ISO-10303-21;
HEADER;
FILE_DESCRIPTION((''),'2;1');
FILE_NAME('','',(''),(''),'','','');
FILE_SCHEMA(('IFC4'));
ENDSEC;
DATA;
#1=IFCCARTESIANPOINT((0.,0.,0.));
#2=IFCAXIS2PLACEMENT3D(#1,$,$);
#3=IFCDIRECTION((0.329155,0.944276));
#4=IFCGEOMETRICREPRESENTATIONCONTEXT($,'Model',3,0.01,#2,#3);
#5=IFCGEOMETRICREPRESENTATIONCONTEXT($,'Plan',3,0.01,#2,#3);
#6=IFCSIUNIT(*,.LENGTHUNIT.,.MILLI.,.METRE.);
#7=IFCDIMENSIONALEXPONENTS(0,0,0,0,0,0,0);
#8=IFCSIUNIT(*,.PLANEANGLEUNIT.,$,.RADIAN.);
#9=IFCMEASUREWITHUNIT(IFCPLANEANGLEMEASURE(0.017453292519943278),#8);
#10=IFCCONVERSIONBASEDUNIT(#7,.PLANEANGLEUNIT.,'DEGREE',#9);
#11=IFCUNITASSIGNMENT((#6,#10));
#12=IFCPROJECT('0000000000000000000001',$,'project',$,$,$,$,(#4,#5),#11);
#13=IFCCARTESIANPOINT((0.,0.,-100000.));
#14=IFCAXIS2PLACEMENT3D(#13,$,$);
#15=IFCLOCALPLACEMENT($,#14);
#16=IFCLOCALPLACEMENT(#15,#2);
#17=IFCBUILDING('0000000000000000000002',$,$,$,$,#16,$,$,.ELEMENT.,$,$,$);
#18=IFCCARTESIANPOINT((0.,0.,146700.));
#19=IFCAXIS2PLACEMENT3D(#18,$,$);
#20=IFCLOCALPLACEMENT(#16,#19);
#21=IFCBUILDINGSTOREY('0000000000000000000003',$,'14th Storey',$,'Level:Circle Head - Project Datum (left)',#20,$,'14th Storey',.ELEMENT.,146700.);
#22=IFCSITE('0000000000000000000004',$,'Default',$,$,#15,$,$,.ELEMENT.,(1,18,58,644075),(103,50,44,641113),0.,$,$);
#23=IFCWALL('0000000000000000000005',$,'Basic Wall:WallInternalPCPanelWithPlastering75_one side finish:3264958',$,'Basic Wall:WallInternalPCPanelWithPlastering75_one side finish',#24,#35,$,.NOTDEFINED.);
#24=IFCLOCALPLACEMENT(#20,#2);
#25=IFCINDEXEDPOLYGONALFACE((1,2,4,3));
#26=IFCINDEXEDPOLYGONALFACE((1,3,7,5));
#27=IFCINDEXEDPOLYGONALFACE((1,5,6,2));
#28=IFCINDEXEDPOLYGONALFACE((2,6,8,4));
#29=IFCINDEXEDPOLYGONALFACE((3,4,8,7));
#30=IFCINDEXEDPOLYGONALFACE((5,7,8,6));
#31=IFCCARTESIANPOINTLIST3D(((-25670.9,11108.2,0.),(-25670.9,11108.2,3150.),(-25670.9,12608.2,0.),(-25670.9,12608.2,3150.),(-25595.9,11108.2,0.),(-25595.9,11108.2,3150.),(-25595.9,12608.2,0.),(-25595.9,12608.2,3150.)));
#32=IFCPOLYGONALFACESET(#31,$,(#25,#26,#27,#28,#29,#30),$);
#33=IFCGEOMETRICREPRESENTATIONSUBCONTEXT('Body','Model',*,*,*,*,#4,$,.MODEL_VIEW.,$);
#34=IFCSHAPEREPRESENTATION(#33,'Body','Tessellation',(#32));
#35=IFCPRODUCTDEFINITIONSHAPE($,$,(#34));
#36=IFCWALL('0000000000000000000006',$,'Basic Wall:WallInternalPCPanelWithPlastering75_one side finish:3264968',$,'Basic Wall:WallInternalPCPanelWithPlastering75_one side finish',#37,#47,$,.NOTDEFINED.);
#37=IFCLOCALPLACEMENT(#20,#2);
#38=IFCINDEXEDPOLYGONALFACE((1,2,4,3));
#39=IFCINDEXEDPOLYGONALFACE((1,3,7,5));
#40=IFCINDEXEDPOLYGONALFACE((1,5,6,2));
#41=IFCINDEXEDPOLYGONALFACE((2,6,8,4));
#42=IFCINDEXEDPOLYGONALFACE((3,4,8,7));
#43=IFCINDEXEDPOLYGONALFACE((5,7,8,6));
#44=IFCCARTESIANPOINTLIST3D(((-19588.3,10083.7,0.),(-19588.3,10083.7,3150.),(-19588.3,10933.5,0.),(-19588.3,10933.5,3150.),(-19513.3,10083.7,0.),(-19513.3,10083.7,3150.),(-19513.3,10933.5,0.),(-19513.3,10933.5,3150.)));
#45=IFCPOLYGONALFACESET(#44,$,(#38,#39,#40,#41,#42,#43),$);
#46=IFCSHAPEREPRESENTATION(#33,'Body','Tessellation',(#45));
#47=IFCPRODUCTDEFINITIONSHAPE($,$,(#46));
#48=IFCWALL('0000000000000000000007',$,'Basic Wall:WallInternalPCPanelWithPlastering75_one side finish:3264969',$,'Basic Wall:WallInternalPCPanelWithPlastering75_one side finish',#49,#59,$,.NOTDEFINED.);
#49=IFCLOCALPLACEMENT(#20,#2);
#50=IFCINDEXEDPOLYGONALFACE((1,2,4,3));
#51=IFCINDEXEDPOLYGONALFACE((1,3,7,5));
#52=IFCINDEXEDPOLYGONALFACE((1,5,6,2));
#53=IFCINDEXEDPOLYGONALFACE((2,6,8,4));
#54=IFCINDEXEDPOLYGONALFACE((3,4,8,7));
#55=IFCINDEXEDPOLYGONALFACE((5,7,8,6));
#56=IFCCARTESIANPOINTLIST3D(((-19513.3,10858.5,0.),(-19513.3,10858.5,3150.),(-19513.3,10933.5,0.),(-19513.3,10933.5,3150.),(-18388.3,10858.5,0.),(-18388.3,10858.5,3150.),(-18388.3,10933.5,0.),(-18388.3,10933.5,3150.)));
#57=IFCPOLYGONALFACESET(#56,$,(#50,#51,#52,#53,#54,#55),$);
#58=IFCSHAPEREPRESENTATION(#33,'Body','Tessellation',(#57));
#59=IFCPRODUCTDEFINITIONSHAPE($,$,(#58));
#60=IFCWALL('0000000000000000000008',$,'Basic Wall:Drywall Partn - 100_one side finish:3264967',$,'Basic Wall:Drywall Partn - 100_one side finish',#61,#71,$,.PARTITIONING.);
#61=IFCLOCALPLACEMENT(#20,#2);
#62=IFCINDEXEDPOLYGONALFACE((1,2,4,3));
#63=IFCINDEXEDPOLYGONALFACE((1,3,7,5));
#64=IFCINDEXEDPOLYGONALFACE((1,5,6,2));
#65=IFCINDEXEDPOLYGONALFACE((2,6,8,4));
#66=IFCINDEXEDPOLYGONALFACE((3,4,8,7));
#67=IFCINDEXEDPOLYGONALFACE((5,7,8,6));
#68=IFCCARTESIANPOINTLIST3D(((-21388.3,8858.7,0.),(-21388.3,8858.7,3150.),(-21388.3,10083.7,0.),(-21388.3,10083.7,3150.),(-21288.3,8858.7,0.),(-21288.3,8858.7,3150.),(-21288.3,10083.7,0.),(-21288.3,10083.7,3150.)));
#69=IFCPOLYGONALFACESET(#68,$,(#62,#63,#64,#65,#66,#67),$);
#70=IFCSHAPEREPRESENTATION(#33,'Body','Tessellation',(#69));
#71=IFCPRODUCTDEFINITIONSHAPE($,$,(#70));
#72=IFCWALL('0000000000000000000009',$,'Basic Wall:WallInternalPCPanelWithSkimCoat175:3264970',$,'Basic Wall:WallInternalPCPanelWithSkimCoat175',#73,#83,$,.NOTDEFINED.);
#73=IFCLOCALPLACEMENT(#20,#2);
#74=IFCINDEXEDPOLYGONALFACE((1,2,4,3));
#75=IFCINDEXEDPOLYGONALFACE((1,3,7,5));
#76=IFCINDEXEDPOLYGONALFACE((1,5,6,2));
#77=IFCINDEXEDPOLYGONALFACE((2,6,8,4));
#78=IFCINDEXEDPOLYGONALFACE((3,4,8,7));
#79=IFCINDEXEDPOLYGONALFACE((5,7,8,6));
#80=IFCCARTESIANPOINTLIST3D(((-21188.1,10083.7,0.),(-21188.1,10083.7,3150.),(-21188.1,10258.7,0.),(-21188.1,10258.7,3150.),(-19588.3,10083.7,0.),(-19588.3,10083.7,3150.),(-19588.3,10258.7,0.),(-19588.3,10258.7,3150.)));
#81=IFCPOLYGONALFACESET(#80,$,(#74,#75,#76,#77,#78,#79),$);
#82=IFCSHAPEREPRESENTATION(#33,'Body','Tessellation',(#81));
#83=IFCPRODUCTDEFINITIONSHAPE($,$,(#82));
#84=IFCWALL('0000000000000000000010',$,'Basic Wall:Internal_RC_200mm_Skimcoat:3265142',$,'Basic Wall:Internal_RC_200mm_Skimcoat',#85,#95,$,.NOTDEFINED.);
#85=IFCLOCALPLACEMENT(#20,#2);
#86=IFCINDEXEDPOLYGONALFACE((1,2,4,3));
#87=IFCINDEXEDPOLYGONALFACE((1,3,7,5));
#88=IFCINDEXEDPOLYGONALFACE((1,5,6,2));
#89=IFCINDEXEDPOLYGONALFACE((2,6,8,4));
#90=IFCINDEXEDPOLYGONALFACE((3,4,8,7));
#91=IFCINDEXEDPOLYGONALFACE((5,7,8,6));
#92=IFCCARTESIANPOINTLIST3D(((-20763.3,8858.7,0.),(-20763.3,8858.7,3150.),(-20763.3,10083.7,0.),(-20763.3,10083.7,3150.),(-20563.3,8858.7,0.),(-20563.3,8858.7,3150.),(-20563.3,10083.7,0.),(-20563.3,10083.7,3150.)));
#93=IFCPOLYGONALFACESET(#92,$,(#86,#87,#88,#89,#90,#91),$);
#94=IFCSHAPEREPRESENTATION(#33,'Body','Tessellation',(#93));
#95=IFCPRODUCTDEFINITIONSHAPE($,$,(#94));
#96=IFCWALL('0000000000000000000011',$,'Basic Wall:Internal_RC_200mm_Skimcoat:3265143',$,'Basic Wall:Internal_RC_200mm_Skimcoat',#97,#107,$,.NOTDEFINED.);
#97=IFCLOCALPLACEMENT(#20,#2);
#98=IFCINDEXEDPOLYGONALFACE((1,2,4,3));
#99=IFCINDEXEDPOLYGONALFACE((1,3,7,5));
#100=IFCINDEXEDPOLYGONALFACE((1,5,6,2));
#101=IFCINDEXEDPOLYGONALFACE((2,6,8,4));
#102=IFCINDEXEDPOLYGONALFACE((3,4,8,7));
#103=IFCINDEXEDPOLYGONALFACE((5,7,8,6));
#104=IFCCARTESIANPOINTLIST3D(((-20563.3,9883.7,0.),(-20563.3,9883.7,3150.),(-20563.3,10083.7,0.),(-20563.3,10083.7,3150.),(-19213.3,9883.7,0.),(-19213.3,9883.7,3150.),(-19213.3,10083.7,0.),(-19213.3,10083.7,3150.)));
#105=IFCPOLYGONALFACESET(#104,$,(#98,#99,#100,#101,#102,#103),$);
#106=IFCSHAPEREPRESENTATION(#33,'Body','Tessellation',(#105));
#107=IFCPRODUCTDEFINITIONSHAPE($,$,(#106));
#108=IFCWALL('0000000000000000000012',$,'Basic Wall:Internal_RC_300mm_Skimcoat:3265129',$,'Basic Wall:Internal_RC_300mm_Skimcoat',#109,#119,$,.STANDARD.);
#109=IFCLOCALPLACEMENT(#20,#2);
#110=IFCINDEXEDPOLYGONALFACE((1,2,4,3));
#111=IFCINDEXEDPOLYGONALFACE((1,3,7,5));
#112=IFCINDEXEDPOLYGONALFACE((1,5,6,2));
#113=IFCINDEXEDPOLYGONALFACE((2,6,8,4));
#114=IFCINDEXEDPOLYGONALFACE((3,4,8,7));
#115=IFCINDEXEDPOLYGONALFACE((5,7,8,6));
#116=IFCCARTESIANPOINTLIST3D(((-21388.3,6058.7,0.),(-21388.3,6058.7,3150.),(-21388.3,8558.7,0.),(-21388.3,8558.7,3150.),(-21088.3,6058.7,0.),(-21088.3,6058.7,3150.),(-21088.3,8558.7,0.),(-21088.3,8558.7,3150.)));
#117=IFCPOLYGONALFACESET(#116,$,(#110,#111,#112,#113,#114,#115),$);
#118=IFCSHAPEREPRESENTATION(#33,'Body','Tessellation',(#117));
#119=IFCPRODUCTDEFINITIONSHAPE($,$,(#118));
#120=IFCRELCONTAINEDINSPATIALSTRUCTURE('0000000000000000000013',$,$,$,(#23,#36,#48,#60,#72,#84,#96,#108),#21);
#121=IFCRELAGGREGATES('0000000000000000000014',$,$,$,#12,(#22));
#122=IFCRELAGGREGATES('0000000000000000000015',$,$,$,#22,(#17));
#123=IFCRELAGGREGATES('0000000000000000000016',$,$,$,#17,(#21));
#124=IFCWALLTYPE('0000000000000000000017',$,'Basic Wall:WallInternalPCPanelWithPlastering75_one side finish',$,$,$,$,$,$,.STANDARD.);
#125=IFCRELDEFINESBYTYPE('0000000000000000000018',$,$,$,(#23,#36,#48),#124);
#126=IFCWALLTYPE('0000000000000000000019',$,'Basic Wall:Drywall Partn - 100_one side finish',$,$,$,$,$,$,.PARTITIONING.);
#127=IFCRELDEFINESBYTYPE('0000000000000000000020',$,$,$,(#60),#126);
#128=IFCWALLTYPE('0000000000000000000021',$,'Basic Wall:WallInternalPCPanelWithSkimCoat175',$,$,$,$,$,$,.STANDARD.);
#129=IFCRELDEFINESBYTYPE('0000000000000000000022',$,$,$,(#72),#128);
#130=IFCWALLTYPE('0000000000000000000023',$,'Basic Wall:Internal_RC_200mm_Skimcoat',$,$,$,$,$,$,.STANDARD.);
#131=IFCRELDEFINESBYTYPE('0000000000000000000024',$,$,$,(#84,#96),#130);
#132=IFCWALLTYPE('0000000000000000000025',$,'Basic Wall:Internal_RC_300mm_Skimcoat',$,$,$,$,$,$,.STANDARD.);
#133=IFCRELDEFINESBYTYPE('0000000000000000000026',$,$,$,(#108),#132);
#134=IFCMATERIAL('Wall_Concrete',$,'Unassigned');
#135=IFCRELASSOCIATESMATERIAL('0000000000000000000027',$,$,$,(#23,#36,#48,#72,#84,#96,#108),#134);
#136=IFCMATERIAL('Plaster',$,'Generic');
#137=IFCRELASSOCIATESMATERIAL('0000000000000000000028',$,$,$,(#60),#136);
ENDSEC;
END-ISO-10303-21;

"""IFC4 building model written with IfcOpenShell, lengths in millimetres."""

from ifc_helpers import new_model, entity, si_unit, converted_unit, direction, frame, origin, place, context, subcontext, project, spatial, indexed_curve, outline, extrude, material, type_object, element, save


model = new_model("IFC4")

# Units and contexts
model_context = context("Model", 3, precision=0.01, world=origin(), true_north=direction((0.329155, 0.944276)))
plan_context = context("Plan", 3, precision=0.01, world=origin(), true_north=direction((0.329155, 0.944276)))
body_context = subcontext(model_context, "Body", "Model", "MODEL_VIEW")
ifc_project = project(units=[si_unit("LENGTHUNIT", "METRE", prefix="MILLI"), converted_unit("PLANEANGLEUNIT", "DEGREE", entity("IfcPlaneAngleMeasure", 0.017453292519943278), si_unit("PLANEANGLEUNIT", "RADIAN"), dimensions=[0, 0, 0, 0, 0, 0, 0])], contexts=[model_context, plan_context])

# Site, building, storey
site_placement = place(None, frame((0.0, 0.0, -100000.0)))
site = spatial("IfcSite", under=ifc_project, at=site_placement, Name="Default", CompositionType="ELEMENT", RefLatitude=(1, 18, 58, 644075), RefLongitude=(103, 50, 44, 641113), RefElevation=0.0)
building_placement = place(site_placement, origin())
building = spatial("IfcBuilding", under=site, at=building_placement, CompositionType="ELEMENT")
storey_placement = place(building_placement, frame((0.0, 0.0, 146700.0)))
storey = spatial("IfcBuildingStorey", under=building, at=storey_placement, Name="14th Storey", ObjectType="Level:Circle Head - Project Datum (left)", LongName="14th Storey", CompositionType="ELEMENT", Elevation=146700.0)

# Walls
ifc_material_1 = material(Name="Wall_Concrete", Category="Unassigned")
wall_type_1 = type_object("IfcWallType", Name="Basic Wall:WallInternalPCPanelWithPlastering75_one side finish", PredefinedType="STANDARD")
wall_1_placement = place(storey_placement, frame((-25633.4, 11108.2, 0.0), z_axis=(0.0, 0.0, 1.0), x_axis=(0.0, 1.0, 0.0)))
element("IfcWall", 1, at=wall_1_placement, inside=storey, type_object=wall_type_1, material=ifc_material_1, Name="Basic Wall:WallInternalPCPanelWithPlastering75_one side finish:3264958", ObjectType="Basic Wall:WallInternalPCPanelWithPlastering75_one side finish", PredefinedType="NOTDEFINED", context=body_context, shape_type="SweptSolid", body=[
    extrude(outline(indexed_curve([(1500.0, 37.5), (0.0, 37.5), (0.0, -37.5), (1500.0, -37.5), (1500.0, 37.5)], self_intersect=False)), origin(), (0.0, 0.0, 1.0), 3150.0),
])
wall_2_placement = place(storey_placement, frame((-19550.8, 10083.7, 0.0), z_axis=(0.0, 0.0, 1.0), x_axis=(0.0, 1.0, 0.0)))
element("IfcWall", 2, at=wall_2_placement, inside=storey, type_object=wall_type_1, material=ifc_material_1, Name="Basic Wall:WallInternalPCPanelWithPlastering75_one side finish:3264968", ObjectType="Basic Wall:WallInternalPCPanelWithPlastering75_one side finish", PredefinedType="NOTDEFINED", context=body_context, shape_type="SweptSolid", body=[
    extrude(outline(indexed_curve([(849.8, 37.5), (0.0, 37.5), (0.0, -37.5), (849.8, -37.5), (849.8, 37.5)], self_intersect=False)), origin(), (0.0, 0.0, 1.0), 3150.0),
])
wall_3_placement = place(storey_placement, frame((-19513.3, 10896.0, 0.0)))
element("IfcWall", 3, at=wall_3_placement, inside=storey, type_object=wall_type_1, material=ifc_material_1, Name="Basic Wall:WallInternalPCPanelWithPlastering75_one side finish:3264969", ObjectType="Basic Wall:WallInternalPCPanelWithPlastering75_one side finish", PredefinedType="NOTDEFINED", context=body_context, shape_type="SweptSolid", body=[
    extrude(outline(indexed_curve([(1125.1, 37.5), (0.0, 37.5), (0.0, -37.5), (1125.1, -37.5), (1125.1, 37.5)], self_intersect=False)), origin(), (0.0, 0.0, 1.0), 3150.0),
])
ifc_material_2 = material(Name="Plaster", Category="Generic")
wall_type_2 = type_object("IfcWallType", Name="Basic Wall:Drywall Partn - 100_one side finish", PredefinedType="PARTITIONING")
wall_4_placement = place(storey_placement, frame((-21338.3, 8858.7, 0.0), z_axis=(0.0, 0.0, 1.0), x_axis=(0.0, 1.0, 0.0)))
element("IfcWall", 4, at=wall_4_placement, inside=storey, type_object=wall_type_2, material=ifc_material_2, Name="Basic Wall:Drywall Partn - 100_one side finish:3264967", ObjectType="Basic Wall:Drywall Partn - 100_one side finish", PredefinedType="PARTITIONING", context=body_context, shape_type="SweptSolid", body=[
    extrude(outline(indexed_curve([(1225.0, 50.0), (0.0, 50.0), (0.0, -50.0), (1225.0, -50.0), (1225.0, 50.0)], self_intersect=False)), origin(), (0.0, 0.0, 1.0), 3150.0),
])
wall_type_3 = type_object("IfcWallType", Name="Basic Wall:WallInternalPCPanelWithSkimCoat175", PredefinedType="STANDARD")
wall_5_placement = place(storey_placement, frame((-19588.3, 10171.2, 0.0), z_axis=(0.0, 0.0, 1.0), x_axis=(-1.0, 0.0, 0.0)))
element("IfcWall", 5, at=wall_5_placement, inside=storey, type_object=wall_type_3, material=ifc_material_1, Name="Basic Wall:WallInternalPCPanelWithSkimCoat175:3264970", ObjectType="Basic Wall:WallInternalPCPanelWithSkimCoat175", PredefinedType="NOTDEFINED", context=body_context, shape_type="SweptSolid", body=[
    extrude(outline(indexed_curve([(1599.7, 87.5), (0.0, 87.5), (0.0, -87.5), (1599.7, -87.5), (1599.7, 87.5)], self_intersect=False)), origin(), (0.0, 0.0, 1.0), 3150.0),
])
wall_type_4 = type_object("IfcWallType", Name="Basic Wall:Internal_RC_200mm_Skimcoat", PredefinedType="STANDARD")
wall_6_placement = place(storey_placement, frame((-20663.3, 8858.7, 0.0), z_axis=(0.0, 0.0, 1.0), x_axis=(0.0, 1.0, 0.0)))
element("IfcWall", 6, at=wall_6_placement, inside=storey, type_object=wall_type_4, material=ifc_material_1, Name="Basic Wall:Internal_RC_200mm_Skimcoat:3265142", ObjectType="Basic Wall:Internal_RC_200mm_Skimcoat", PredefinedType="NOTDEFINED", context=body_context, shape_type="SweptSolid", body=[
    extrude(outline(indexed_curve([(1225.0, 100.0), (0.0, 100.0), (0.0, -100.0), (1225.0, -100.0), (1225.0, 100.0)], self_intersect=False)), origin(), (0.0, 0.0, 1.0), 3150.0),
])
wall_7_placement = place(storey_placement, frame((-20563.3, 9983.7, 0.0)))
element("IfcWall", 7, at=wall_7_placement, inside=storey, type_object=wall_type_4, material=ifc_material_1, Name="Basic Wall:Internal_RC_200mm_Skimcoat:3265143", ObjectType="Basic Wall:Internal_RC_200mm_Skimcoat", PredefinedType="NOTDEFINED", context=body_context, shape_type="SweptSolid", body=[
    extrude(outline(indexed_curve([(1350.0, 100.0), (0.0, 100.0), (0.0, -100.0), (1350.0, -100.0), (1350.0, 100.0)], self_intersect=False)), origin(), (0.0, 0.0, 1.0), 3150.0),
])
wall_type_5 = type_object("IfcWallType", Name="Basic Wall:Internal_RC_300mm_Skimcoat", PredefinedType="STANDARD")
wall_8_placement = place(storey_placement, frame((-21238.3, 8558.7, 0.0), z_axis=(0.0, 0.0, 1.0), x_axis=(0.0, -1.0, 0.0)))
element("IfcWall", 8, at=wall_8_placement, inside=storey, type_object=wall_type_5, material=ifc_material_1, Name="Basic Wall:Internal_RC_300mm_Skimcoat:3265129", ObjectType="Basic Wall:Internal_RC_300mm_Skimcoat", PredefinedType="STANDARD", context=body_context, shape_type="SweptSolid", body=[
    extrude(outline(indexed_curve([(2500.0, 150.0), (0.0, 150.0), (0.0, -150.0), (2500.0, -150.0), (2500.0, 150.0)], self_intersect=False)), origin(), (0.0, 0.0, 1.0), 3150.0),
])

save(model, "model.ifc")
